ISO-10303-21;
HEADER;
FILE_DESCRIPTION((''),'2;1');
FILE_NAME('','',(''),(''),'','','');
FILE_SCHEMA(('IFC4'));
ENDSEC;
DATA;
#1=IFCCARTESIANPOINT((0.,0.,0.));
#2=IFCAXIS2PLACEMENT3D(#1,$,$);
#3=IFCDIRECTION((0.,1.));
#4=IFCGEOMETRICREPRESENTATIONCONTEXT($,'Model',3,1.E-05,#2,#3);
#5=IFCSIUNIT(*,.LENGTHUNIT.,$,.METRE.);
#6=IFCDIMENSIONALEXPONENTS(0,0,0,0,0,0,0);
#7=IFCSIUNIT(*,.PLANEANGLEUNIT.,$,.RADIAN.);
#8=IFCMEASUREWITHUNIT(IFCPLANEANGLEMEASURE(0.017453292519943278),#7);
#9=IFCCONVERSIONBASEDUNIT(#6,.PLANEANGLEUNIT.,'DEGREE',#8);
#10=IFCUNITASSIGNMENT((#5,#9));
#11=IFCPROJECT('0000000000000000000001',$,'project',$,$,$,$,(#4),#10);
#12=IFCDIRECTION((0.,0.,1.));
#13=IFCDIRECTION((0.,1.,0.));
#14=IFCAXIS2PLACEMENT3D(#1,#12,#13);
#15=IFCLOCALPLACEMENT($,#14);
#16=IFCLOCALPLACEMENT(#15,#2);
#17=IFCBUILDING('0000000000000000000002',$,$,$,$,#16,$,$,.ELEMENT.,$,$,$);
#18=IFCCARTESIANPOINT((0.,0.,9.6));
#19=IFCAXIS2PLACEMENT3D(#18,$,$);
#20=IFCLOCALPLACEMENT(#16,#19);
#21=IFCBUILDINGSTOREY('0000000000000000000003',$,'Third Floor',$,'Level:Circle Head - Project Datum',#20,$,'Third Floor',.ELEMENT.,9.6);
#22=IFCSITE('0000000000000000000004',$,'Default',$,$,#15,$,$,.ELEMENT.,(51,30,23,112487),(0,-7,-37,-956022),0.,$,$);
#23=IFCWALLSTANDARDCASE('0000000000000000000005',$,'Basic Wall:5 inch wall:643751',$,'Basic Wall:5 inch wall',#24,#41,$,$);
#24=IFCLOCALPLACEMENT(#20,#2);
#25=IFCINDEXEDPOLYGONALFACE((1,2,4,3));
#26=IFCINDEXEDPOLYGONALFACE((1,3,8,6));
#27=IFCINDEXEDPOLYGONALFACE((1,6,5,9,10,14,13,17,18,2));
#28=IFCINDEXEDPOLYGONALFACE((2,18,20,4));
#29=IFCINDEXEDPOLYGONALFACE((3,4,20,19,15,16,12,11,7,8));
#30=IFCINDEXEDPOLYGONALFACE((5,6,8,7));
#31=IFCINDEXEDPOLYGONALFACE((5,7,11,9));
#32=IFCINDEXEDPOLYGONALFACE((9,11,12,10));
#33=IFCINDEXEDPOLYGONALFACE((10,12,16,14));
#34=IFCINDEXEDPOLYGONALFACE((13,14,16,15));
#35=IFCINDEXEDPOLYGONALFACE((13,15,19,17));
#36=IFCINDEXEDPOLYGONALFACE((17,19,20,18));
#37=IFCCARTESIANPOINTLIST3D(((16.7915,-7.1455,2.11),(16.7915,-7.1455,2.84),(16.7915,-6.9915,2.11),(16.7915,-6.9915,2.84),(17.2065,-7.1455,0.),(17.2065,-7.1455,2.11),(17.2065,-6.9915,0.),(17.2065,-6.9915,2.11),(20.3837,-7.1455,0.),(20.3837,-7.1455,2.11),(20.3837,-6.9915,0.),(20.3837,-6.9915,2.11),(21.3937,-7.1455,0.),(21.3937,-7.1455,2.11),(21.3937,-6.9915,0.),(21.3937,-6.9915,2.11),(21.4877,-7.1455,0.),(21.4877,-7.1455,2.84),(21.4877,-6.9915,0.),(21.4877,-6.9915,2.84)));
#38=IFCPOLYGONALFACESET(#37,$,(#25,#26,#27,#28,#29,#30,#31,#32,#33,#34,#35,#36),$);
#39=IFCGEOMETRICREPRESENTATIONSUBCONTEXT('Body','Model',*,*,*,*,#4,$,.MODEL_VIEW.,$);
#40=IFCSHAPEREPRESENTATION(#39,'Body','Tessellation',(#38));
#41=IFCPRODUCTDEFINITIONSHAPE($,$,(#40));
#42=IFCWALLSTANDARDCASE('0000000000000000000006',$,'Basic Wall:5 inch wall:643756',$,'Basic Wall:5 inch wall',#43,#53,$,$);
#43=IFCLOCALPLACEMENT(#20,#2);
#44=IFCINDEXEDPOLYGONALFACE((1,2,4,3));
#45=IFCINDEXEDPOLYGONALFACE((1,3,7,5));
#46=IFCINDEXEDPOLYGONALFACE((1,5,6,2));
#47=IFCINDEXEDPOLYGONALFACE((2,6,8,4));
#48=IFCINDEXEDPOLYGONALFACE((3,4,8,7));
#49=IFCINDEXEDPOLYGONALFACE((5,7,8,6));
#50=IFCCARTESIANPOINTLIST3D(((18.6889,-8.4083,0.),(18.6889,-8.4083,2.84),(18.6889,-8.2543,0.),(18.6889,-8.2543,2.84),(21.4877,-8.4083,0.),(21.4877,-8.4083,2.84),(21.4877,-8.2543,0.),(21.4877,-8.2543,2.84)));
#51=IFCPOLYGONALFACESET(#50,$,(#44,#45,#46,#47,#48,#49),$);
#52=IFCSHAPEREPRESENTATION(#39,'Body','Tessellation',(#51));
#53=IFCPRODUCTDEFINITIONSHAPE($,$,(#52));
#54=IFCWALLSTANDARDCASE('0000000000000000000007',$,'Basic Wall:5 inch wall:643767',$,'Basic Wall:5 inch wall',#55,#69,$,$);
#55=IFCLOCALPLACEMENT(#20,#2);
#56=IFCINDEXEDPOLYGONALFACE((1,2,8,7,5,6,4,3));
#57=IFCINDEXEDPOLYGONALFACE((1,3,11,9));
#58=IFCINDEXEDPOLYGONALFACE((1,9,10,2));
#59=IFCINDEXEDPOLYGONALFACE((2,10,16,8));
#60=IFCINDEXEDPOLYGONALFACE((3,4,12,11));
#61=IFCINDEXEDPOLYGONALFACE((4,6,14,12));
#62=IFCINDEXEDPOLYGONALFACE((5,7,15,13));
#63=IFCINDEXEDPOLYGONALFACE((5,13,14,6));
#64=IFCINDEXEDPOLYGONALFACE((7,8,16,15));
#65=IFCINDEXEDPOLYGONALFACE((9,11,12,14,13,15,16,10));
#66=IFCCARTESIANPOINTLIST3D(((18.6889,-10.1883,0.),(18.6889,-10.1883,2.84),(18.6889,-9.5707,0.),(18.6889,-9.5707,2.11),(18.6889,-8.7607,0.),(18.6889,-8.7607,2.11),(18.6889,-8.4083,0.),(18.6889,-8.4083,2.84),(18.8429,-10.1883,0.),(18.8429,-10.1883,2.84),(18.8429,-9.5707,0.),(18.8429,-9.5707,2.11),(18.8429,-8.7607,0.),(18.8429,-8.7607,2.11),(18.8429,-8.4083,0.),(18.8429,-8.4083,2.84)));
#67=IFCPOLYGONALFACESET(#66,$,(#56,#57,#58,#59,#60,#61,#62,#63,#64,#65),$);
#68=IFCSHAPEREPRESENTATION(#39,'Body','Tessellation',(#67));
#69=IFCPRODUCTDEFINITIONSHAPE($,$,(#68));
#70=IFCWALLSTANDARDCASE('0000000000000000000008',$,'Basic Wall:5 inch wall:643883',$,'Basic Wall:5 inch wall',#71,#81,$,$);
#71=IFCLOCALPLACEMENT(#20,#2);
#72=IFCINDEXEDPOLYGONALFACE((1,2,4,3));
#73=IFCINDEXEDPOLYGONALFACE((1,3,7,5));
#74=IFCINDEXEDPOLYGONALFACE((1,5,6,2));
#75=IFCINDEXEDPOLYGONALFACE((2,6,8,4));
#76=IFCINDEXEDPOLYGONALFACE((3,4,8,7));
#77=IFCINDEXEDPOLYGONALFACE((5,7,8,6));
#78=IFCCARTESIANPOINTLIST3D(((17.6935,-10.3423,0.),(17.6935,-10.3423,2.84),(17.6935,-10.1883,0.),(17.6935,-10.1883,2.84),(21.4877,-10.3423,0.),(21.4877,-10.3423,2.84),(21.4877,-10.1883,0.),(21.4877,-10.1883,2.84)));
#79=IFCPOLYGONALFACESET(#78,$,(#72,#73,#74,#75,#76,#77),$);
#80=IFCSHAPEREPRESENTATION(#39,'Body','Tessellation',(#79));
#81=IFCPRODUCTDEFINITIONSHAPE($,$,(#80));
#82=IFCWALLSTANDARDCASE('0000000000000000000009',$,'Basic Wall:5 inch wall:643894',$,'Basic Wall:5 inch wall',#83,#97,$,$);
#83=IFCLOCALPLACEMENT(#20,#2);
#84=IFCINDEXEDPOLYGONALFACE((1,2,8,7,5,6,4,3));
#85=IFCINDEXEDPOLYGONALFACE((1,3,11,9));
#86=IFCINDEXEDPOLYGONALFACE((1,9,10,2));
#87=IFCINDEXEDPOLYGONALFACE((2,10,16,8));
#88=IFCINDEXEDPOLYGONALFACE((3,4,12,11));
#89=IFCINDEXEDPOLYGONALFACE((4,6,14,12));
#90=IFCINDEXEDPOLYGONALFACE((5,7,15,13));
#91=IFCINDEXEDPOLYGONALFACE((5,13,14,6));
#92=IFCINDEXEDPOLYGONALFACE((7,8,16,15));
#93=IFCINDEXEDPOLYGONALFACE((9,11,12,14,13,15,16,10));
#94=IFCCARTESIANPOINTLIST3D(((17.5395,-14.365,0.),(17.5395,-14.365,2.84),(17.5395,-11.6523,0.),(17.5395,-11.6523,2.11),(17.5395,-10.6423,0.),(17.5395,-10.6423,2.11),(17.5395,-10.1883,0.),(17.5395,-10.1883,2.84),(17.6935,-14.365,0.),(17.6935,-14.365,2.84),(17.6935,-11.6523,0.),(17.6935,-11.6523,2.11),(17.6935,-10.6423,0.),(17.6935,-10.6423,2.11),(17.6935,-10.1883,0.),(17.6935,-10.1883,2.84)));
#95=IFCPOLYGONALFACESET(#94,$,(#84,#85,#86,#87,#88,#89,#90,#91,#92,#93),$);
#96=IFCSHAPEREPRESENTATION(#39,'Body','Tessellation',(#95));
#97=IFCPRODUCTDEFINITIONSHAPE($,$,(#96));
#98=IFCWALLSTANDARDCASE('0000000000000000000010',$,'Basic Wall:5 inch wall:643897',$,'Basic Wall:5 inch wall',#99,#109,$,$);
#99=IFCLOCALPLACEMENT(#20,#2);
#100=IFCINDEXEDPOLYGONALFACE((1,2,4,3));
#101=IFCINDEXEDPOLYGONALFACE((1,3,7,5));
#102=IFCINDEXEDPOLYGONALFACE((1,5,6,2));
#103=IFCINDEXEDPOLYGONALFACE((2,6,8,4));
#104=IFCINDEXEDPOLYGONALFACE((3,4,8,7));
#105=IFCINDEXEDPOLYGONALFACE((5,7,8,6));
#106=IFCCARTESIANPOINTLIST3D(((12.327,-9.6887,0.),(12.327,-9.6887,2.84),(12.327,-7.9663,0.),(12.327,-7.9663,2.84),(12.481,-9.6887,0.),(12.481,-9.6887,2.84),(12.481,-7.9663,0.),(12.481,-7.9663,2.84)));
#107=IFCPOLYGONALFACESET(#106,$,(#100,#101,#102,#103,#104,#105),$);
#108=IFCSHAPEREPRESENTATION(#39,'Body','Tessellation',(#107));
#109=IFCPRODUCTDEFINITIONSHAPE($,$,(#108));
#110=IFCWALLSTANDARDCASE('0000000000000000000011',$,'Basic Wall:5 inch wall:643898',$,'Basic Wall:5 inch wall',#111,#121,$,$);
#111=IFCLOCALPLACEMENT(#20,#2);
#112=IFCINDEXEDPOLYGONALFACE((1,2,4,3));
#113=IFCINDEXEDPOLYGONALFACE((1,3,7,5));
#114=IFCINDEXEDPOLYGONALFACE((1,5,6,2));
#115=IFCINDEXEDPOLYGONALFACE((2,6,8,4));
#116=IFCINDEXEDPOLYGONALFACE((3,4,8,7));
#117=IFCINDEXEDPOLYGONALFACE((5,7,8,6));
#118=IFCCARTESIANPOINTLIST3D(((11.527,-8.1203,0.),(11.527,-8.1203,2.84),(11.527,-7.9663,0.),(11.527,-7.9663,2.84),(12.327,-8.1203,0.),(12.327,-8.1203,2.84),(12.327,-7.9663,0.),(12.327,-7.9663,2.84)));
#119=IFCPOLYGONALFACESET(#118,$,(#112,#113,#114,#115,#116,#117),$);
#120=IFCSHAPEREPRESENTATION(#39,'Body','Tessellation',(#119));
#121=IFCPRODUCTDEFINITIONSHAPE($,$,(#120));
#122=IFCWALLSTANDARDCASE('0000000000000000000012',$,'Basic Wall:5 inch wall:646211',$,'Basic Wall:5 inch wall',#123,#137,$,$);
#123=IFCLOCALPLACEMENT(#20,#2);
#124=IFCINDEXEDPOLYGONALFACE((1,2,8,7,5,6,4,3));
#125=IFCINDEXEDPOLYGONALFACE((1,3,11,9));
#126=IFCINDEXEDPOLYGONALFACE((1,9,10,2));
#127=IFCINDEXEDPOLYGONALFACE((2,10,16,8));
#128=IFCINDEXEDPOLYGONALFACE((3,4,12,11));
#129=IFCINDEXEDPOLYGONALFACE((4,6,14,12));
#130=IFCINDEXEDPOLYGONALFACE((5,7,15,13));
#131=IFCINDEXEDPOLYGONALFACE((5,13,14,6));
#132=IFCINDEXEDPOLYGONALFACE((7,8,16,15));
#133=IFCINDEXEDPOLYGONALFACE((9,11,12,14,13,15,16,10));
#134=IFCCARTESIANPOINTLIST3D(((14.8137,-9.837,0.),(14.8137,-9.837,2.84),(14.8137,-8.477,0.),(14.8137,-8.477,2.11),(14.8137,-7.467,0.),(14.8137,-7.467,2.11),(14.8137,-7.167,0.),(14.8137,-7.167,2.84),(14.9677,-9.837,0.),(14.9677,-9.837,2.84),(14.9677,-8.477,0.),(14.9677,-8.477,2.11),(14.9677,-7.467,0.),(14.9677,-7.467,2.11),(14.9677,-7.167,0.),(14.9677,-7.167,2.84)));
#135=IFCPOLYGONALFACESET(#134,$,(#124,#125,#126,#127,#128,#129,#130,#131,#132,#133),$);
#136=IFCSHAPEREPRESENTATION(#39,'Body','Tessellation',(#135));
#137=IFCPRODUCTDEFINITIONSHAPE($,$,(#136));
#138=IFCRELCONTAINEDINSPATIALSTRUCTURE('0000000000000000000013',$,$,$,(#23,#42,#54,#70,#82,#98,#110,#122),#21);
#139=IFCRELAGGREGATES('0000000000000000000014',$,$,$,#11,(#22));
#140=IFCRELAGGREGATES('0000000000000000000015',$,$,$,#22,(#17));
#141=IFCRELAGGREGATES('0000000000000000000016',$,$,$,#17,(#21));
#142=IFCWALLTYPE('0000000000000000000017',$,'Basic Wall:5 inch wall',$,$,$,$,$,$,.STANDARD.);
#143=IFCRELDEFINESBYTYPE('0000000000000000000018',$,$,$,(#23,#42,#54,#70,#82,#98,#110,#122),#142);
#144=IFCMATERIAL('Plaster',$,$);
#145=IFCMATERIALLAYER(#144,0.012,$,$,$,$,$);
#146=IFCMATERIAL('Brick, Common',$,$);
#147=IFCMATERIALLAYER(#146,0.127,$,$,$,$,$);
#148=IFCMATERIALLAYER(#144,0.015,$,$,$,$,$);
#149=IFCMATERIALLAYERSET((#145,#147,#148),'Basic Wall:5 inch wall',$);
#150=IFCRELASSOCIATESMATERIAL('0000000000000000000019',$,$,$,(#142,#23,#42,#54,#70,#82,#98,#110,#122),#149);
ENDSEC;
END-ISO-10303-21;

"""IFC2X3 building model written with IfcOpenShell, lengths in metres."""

from ifc_helpers import new_model, entity, si_unit, converted_unit, direction, frame, frame_2d, origin, place, context, subcontext, project, spatial, rectangle, extrude, material, layer, layer_set, layer_usage, type_object, element, save


model = new_model("IFC2X3")

# Units and contexts
model_context = context("Model", 3, precision=1e-05, world=origin(), true_north=direction((0.0, 1.0)))
body_context = subcontext(model_context, "Body", "Model", "MODEL_VIEW")
ifc_project = project(units=[si_unit("LENGTHUNIT", "METRE"), converted_unit("PLANEANGLEUNIT", "DEGREE", entity("IfcPlaneAngleMeasure", 0.017453292519943278), si_unit("PLANEANGLEUNIT", "RADIAN"), dimensions=[0, 0, 0, 0, 0, 0, 0])], contexts=[model_context])

# Site, building, storey
site_placement = place(None, frame((0.0, 0.0, 0.0), z_axis=(0.0, 0.0, 1.0), x_axis=(0.0, 1.0, 0.0)))
site = spatial("IfcSite", under=ifc_project, at=site_placement, Name="Default", CompositionType="ELEMENT", RefLatitude=(51, 30, 23, 112487), RefLongitude=(0, -7, -37, -956022), RefElevation=0.0)
building_placement = place(site_placement, origin())
building = spatial("IfcBuilding", under=site, at=building_placement, CompositionType="ELEMENT")
storey_placement = place(building_placement, frame((0.0, 0.0, 9.6)))
storey = spatial("IfcBuildingStorey", under=building, at=storey_placement, Name="Third Floor", ObjectType="Level:Circle Head - Project Datum", LongName="Third Floor", CompositionType="ELEMENT", Elevation=9.6)

# Wall, openings
ifc_material_1 = material(Name="Plaster")
ifc_layer_1 = layer(ifc_material_1, 0.012)
ifc_material_2 = material(Name="Brick, Common")
ifc_layer_2 = layer(ifc_material_2, 0.127)
ifc_layer_3 = layer(ifc_material_1, 0.015)
ifc_layer_set = layer_set([ifc_layer_1, ifc_layer_2, ifc_layer_3], Name="Basic Wall:5 inch wall")
ifc_layer_usage_1 = layer_usage(ifc_layer_set, "AXIS2", "NEGATIVE", 0.077)
wall_type = type_object("IfcWallType", Name="Basic Wall:5 inch wall", PredefinedType="STANDARD", material=ifc_layer_set)
wall_1_placement = place(storey_placement, frame((21.4877, -7.0685, 0.0), z_axis=(0.0, 0.0, 1.0), x_axis=(-1.0, 0.0, 0.0)))
wall_1 = element("IfcWallStandardCase", 1, at=wall_1_placement, inside=storey, type_object=wall_type, material=ifc_layer_usage_1, Name="Basic Wall:5 inch wall:643751", ObjectType="Basic Wall:5 inch wall", context=body_context, shape_type="SweptSolid", body=[
    extrude(rectangle(XDim=4.6962, YDim=0.154, at=frame_2d((2.3481, 0.0), x_axis=(-1.0, 0.0))), origin(), (0.0, 0.0, 1.0), 2.84),
])
opening_1_placement = place(wall_1_placement, frame((5.0912, 0.077, 0.0)))
element("IfcOpeningElement", 2, at=opening_1_placement, cuts=wall_1, ObjectType="Opening", context=body_context, shape_type="SweptSolid", body=[
    extrude(rectangle(XDim=2.11, YDim=0.81, at=frame_2d((1.055, 0.405), x_axis=(1.0, 0.0))), frame((0.0, 0.0, 0.0), z_axis=(0.0, -1.0, 0.0), x_axis=(0.0, 0.0, 1.0)), (0.0, 0.0, 1.0), 0.154),
])
opening_2_placement = place(wall_1_placement, frame((0.094, -0.077, 0.0)))
element("IfcOpeningElement", 3, at=opening_2_placement, cuts=wall_1, ObjectType="Opening", context=body_context, shape_type="SweptSolid", body=[
    extrude(rectangle(XDim=2.11, YDim=1.01, at=frame_2d((1.055, 0.505), x_axis=(1.0, 0.0))), frame((0.0, 0.0, 0.0), z_axis=(0.0, 1.0, 0.0), x_axis=(0.0, 0.0, 1.0)), (0.0, 0.0, 1.0), 0.154),
])

# Wall
ifc_layer_usage_2 = layer_usage(ifc_layer_set, "AXIS2", "NEGATIVE", 0.077)
wall_2_placement = place(storey_placement, frame((18.6889, -8.3313, 0.0)))
element("IfcWallStandardCase", 4, at=wall_2_placement, inside=storey, type_object=wall_type, material=ifc_layer_usage_2, Name="Basic Wall:5 inch wall:643756", ObjectType="Basic Wall:5 inch wall", context=body_context, shape_type="SweptSolid", body=[
    extrude(rectangle(XDim=2.7989, YDim=0.154, at=frame_2d((1.3994, 0.0), x_axis=(-1.0, 0.0))), origin(), (0.0, 0.0, 1.0), 2.84),
])

# Wall, opening
ifc_layer_usage_3 = layer_usage(ifc_layer_set, "AXIS2", "NEGATIVE", 0.077)
wall_3_placement = place(storey_placement, frame((18.7659, -8.4083, 0.0), z_axis=(0.0, 0.0, 1.0), x_axis=(0.0, -1.0, 0.0)))
wall_3 = element("IfcWallStandardCase", 5, at=wall_3_placement, inside=storey, type_object=wall_type, material=ifc_layer_usage_3, Name="Basic Wall:5 inch wall:643767", ObjectType="Basic Wall:5 inch wall", context=body_context, shape_type="SweptSolid", body=[
    extrude(rectangle(XDim=1.78, YDim=0.154, at=frame_2d((0.89, 0.0), x_axis=(-1.0, 0.0))), origin(), (0.0, 0.0, 1.0), 2.84),
])
opening_3_placement = place(wall_3_placement, frame((1.1624, 0.077, 0.0)))
element("IfcOpeningElement", 6, at=opening_3_placement, cuts=wall_3, ObjectType="Opening", context=body_context, shape_type="SweptSolid", body=[
    extrude(rectangle(XDim=2.11, YDim=0.81, at=frame_2d((1.055, 0.405), x_axis=(1.0, 0.0))), frame((0.0, 0.0, 0.0), z_axis=(0.0, -1.0, 0.0), x_axis=(0.0, 0.0, 1.0)), (0.0, 0.0, 1.0), 0.154),
])

# Wall
ifc_layer_usage_4 = layer_usage(ifc_layer_set, "AXIS2", "NEGATIVE", 0.077)
wall_4_placement = place(storey_placement, frame((17.6935, -10.2653, 0.0)))
element("IfcWallStandardCase", 7, at=wall_4_placement, inside=storey, type_object=wall_type, material=ifc_layer_usage_4, Name="Basic Wall:5 inch wall:643883", ObjectType="Basic Wall:5 inch wall", context=body_context, shape_type="SweptSolid", body=[
    extrude(rectangle(XDim=3.7942, YDim=0.154, at=frame_2d((1.8971, 0.0), x_axis=(-1.0, 0.0))), origin(), (0.0, 0.0, 1.0), 2.84),
])

# Wall, opening
ifc_layer_usage_5 = layer_usage(ifc_layer_set, "AXIS2", "NEGATIVE", 0.077)
wall_5_placement = place(storey_placement, frame((17.6165, -10.1883, 0.0), z_axis=(0.0, 0.0, 1.0), x_axis=(0.0, -1.0, 0.0)))
wall_5 = element("IfcWallStandardCase", 8, at=wall_5_placement, inside=storey, type_object=wall_type, material=ifc_layer_usage_5, Name="Basic Wall:5 inch wall:643894", ObjectType="Basic Wall:5 inch wall", context=body_context, shape_type="SweptSolid", body=[
    extrude(rectangle(XDim=4.1767, YDim=0.154, at=frame_2d((2.0884, 0.0), x_axis=(1.0, 0.0))), origin(), (0.0, 0.0, 1.0), 2.84),
])
opening_4_placement = place(wall_5_placement, frame((0.454, -0.077, 0.0)))
element("IfcOpeningElement", 9, at=opening_4_placement, cuts=wall_5, ObjectType="Opening", context=body_context, shape_type="SweptSolid", body=[
    extrude(rectangle(XDim=2.11, YDim=1.01, at=frame_2d((1.055, 0.505), x_axis=(1.0, 0.0))), frame((0.0, 0.0, 0.0), z_axis=(0.0, 1.0, 0.0), x_axis=(0.0, 0.0, 1.0)), (0.0, 0.0, 1.0), 0.154),
])

# Walls
ifc_layer_usage_6 = layer_usage(ifc_layer_set, "AXIS2", "NEGATIVE", 0.077)
wall_6_placement = place(storey_placement, frame((12.404, -7.9663, 0.0), z_axis=(0.0, 0.0, 1.0), x_axis=(0.0, -1.0, 0.0)))
element("IfcWallStandardCase", 10, at=wall_6_placement, inside=storey, type_object=wall_type, material=ifc_layer_usage_6, Name="Basic Wall:5 inch wall:643897", ObjectType="Basic Wall:5 inch wall", context=body_context, shape_type="SweptSolid", body=[
    extrude(rectangle(XDim=1.7224, YDim=0.154, at=frame_2d((0.8612, 0.0), x_axis=(-1.0, 0.0))), origin(), (0.0, 0.0, 1.0), 2.84),
])
ifc_layer_usage_7 = layer_usage(ifc_layer_set, "AXIS2", "NEGATIVE", 0.077)
wall_7_placement = place(storey_placement, frame((12.327, -8.0433, 0.0), z_axis=(0.0, 0.0, 1.0), x_axis=(-1.0, 0.0, 0.0)))
element("IfcWallStandardCase", 11, at=wall_7_placement, inside=storey, type_object=wall_type, material=ifc_layer_usage_7, Name="Basic Wall:5 inch wall:643898", ObjectType="Basic Wall:5 inch wall", context=body_context, shape_type="SweptSolid", body=[
    extrude(rectangle(XDim=0.8, YDim=0.154, at=frame_2d((0.4, 0.0), x_axis=(-1.0, 0.0))), origin(), (0.0, 0.0, 1.0), 2.84),
])

# Wall, opening
ifc_layer_usage_8 = layer_usage(ifc_layer_set, "AXIS2", "NEGATIVE", 0.077)
wall_8_placement = place(storey_placement, frame((14.8907, -9.837, 0.0), z_axis=(0.0, 0.0, 1.0), x_axis=(0.0, 1.0, 0.0)))
wall_8 = element("IfcWallStandardCase", 12, at=wall_8_placement, inside=storey, type_object=wall_type, material=ifc_layer_usage_8, Name="Basic Wall:5 inch wall:646211", ObjectType="Basic Wall:5 inch wall", context=body_context, shape_type="SweptSolid", body=[
    extrude(rectangle(XDim=2.67, YDim=0.154, at=frame_2d((1.335, 0.0), x_axis=(1.0, 0.0))), origin(), (0.0, 0.0, 1.0), 2.84),
])
opening_5_placement = place(wall_8_placement, frame((2.37, 0.077, 0.0)))
element("IfcOpeningElement", 13, at=opening_5_placement, cuts=wall_8, ObjectType="Opening", context=body_context, shape_type="SweptSolid", body=[
    extrude(rectangle(XDim=2.11, YDim=1.01, at=frame_2d((1.055, 0.505), x_axis=(1.0, 0.0))), frame((0.0, 0.0, 0.0), z_axis=(0.0, -1.0, 0.0), x_axis=(0.0, 0.0, 1.0)), (0.0, 0.0, 1.0), 0.154),
])

save(model, "model.ifc")
